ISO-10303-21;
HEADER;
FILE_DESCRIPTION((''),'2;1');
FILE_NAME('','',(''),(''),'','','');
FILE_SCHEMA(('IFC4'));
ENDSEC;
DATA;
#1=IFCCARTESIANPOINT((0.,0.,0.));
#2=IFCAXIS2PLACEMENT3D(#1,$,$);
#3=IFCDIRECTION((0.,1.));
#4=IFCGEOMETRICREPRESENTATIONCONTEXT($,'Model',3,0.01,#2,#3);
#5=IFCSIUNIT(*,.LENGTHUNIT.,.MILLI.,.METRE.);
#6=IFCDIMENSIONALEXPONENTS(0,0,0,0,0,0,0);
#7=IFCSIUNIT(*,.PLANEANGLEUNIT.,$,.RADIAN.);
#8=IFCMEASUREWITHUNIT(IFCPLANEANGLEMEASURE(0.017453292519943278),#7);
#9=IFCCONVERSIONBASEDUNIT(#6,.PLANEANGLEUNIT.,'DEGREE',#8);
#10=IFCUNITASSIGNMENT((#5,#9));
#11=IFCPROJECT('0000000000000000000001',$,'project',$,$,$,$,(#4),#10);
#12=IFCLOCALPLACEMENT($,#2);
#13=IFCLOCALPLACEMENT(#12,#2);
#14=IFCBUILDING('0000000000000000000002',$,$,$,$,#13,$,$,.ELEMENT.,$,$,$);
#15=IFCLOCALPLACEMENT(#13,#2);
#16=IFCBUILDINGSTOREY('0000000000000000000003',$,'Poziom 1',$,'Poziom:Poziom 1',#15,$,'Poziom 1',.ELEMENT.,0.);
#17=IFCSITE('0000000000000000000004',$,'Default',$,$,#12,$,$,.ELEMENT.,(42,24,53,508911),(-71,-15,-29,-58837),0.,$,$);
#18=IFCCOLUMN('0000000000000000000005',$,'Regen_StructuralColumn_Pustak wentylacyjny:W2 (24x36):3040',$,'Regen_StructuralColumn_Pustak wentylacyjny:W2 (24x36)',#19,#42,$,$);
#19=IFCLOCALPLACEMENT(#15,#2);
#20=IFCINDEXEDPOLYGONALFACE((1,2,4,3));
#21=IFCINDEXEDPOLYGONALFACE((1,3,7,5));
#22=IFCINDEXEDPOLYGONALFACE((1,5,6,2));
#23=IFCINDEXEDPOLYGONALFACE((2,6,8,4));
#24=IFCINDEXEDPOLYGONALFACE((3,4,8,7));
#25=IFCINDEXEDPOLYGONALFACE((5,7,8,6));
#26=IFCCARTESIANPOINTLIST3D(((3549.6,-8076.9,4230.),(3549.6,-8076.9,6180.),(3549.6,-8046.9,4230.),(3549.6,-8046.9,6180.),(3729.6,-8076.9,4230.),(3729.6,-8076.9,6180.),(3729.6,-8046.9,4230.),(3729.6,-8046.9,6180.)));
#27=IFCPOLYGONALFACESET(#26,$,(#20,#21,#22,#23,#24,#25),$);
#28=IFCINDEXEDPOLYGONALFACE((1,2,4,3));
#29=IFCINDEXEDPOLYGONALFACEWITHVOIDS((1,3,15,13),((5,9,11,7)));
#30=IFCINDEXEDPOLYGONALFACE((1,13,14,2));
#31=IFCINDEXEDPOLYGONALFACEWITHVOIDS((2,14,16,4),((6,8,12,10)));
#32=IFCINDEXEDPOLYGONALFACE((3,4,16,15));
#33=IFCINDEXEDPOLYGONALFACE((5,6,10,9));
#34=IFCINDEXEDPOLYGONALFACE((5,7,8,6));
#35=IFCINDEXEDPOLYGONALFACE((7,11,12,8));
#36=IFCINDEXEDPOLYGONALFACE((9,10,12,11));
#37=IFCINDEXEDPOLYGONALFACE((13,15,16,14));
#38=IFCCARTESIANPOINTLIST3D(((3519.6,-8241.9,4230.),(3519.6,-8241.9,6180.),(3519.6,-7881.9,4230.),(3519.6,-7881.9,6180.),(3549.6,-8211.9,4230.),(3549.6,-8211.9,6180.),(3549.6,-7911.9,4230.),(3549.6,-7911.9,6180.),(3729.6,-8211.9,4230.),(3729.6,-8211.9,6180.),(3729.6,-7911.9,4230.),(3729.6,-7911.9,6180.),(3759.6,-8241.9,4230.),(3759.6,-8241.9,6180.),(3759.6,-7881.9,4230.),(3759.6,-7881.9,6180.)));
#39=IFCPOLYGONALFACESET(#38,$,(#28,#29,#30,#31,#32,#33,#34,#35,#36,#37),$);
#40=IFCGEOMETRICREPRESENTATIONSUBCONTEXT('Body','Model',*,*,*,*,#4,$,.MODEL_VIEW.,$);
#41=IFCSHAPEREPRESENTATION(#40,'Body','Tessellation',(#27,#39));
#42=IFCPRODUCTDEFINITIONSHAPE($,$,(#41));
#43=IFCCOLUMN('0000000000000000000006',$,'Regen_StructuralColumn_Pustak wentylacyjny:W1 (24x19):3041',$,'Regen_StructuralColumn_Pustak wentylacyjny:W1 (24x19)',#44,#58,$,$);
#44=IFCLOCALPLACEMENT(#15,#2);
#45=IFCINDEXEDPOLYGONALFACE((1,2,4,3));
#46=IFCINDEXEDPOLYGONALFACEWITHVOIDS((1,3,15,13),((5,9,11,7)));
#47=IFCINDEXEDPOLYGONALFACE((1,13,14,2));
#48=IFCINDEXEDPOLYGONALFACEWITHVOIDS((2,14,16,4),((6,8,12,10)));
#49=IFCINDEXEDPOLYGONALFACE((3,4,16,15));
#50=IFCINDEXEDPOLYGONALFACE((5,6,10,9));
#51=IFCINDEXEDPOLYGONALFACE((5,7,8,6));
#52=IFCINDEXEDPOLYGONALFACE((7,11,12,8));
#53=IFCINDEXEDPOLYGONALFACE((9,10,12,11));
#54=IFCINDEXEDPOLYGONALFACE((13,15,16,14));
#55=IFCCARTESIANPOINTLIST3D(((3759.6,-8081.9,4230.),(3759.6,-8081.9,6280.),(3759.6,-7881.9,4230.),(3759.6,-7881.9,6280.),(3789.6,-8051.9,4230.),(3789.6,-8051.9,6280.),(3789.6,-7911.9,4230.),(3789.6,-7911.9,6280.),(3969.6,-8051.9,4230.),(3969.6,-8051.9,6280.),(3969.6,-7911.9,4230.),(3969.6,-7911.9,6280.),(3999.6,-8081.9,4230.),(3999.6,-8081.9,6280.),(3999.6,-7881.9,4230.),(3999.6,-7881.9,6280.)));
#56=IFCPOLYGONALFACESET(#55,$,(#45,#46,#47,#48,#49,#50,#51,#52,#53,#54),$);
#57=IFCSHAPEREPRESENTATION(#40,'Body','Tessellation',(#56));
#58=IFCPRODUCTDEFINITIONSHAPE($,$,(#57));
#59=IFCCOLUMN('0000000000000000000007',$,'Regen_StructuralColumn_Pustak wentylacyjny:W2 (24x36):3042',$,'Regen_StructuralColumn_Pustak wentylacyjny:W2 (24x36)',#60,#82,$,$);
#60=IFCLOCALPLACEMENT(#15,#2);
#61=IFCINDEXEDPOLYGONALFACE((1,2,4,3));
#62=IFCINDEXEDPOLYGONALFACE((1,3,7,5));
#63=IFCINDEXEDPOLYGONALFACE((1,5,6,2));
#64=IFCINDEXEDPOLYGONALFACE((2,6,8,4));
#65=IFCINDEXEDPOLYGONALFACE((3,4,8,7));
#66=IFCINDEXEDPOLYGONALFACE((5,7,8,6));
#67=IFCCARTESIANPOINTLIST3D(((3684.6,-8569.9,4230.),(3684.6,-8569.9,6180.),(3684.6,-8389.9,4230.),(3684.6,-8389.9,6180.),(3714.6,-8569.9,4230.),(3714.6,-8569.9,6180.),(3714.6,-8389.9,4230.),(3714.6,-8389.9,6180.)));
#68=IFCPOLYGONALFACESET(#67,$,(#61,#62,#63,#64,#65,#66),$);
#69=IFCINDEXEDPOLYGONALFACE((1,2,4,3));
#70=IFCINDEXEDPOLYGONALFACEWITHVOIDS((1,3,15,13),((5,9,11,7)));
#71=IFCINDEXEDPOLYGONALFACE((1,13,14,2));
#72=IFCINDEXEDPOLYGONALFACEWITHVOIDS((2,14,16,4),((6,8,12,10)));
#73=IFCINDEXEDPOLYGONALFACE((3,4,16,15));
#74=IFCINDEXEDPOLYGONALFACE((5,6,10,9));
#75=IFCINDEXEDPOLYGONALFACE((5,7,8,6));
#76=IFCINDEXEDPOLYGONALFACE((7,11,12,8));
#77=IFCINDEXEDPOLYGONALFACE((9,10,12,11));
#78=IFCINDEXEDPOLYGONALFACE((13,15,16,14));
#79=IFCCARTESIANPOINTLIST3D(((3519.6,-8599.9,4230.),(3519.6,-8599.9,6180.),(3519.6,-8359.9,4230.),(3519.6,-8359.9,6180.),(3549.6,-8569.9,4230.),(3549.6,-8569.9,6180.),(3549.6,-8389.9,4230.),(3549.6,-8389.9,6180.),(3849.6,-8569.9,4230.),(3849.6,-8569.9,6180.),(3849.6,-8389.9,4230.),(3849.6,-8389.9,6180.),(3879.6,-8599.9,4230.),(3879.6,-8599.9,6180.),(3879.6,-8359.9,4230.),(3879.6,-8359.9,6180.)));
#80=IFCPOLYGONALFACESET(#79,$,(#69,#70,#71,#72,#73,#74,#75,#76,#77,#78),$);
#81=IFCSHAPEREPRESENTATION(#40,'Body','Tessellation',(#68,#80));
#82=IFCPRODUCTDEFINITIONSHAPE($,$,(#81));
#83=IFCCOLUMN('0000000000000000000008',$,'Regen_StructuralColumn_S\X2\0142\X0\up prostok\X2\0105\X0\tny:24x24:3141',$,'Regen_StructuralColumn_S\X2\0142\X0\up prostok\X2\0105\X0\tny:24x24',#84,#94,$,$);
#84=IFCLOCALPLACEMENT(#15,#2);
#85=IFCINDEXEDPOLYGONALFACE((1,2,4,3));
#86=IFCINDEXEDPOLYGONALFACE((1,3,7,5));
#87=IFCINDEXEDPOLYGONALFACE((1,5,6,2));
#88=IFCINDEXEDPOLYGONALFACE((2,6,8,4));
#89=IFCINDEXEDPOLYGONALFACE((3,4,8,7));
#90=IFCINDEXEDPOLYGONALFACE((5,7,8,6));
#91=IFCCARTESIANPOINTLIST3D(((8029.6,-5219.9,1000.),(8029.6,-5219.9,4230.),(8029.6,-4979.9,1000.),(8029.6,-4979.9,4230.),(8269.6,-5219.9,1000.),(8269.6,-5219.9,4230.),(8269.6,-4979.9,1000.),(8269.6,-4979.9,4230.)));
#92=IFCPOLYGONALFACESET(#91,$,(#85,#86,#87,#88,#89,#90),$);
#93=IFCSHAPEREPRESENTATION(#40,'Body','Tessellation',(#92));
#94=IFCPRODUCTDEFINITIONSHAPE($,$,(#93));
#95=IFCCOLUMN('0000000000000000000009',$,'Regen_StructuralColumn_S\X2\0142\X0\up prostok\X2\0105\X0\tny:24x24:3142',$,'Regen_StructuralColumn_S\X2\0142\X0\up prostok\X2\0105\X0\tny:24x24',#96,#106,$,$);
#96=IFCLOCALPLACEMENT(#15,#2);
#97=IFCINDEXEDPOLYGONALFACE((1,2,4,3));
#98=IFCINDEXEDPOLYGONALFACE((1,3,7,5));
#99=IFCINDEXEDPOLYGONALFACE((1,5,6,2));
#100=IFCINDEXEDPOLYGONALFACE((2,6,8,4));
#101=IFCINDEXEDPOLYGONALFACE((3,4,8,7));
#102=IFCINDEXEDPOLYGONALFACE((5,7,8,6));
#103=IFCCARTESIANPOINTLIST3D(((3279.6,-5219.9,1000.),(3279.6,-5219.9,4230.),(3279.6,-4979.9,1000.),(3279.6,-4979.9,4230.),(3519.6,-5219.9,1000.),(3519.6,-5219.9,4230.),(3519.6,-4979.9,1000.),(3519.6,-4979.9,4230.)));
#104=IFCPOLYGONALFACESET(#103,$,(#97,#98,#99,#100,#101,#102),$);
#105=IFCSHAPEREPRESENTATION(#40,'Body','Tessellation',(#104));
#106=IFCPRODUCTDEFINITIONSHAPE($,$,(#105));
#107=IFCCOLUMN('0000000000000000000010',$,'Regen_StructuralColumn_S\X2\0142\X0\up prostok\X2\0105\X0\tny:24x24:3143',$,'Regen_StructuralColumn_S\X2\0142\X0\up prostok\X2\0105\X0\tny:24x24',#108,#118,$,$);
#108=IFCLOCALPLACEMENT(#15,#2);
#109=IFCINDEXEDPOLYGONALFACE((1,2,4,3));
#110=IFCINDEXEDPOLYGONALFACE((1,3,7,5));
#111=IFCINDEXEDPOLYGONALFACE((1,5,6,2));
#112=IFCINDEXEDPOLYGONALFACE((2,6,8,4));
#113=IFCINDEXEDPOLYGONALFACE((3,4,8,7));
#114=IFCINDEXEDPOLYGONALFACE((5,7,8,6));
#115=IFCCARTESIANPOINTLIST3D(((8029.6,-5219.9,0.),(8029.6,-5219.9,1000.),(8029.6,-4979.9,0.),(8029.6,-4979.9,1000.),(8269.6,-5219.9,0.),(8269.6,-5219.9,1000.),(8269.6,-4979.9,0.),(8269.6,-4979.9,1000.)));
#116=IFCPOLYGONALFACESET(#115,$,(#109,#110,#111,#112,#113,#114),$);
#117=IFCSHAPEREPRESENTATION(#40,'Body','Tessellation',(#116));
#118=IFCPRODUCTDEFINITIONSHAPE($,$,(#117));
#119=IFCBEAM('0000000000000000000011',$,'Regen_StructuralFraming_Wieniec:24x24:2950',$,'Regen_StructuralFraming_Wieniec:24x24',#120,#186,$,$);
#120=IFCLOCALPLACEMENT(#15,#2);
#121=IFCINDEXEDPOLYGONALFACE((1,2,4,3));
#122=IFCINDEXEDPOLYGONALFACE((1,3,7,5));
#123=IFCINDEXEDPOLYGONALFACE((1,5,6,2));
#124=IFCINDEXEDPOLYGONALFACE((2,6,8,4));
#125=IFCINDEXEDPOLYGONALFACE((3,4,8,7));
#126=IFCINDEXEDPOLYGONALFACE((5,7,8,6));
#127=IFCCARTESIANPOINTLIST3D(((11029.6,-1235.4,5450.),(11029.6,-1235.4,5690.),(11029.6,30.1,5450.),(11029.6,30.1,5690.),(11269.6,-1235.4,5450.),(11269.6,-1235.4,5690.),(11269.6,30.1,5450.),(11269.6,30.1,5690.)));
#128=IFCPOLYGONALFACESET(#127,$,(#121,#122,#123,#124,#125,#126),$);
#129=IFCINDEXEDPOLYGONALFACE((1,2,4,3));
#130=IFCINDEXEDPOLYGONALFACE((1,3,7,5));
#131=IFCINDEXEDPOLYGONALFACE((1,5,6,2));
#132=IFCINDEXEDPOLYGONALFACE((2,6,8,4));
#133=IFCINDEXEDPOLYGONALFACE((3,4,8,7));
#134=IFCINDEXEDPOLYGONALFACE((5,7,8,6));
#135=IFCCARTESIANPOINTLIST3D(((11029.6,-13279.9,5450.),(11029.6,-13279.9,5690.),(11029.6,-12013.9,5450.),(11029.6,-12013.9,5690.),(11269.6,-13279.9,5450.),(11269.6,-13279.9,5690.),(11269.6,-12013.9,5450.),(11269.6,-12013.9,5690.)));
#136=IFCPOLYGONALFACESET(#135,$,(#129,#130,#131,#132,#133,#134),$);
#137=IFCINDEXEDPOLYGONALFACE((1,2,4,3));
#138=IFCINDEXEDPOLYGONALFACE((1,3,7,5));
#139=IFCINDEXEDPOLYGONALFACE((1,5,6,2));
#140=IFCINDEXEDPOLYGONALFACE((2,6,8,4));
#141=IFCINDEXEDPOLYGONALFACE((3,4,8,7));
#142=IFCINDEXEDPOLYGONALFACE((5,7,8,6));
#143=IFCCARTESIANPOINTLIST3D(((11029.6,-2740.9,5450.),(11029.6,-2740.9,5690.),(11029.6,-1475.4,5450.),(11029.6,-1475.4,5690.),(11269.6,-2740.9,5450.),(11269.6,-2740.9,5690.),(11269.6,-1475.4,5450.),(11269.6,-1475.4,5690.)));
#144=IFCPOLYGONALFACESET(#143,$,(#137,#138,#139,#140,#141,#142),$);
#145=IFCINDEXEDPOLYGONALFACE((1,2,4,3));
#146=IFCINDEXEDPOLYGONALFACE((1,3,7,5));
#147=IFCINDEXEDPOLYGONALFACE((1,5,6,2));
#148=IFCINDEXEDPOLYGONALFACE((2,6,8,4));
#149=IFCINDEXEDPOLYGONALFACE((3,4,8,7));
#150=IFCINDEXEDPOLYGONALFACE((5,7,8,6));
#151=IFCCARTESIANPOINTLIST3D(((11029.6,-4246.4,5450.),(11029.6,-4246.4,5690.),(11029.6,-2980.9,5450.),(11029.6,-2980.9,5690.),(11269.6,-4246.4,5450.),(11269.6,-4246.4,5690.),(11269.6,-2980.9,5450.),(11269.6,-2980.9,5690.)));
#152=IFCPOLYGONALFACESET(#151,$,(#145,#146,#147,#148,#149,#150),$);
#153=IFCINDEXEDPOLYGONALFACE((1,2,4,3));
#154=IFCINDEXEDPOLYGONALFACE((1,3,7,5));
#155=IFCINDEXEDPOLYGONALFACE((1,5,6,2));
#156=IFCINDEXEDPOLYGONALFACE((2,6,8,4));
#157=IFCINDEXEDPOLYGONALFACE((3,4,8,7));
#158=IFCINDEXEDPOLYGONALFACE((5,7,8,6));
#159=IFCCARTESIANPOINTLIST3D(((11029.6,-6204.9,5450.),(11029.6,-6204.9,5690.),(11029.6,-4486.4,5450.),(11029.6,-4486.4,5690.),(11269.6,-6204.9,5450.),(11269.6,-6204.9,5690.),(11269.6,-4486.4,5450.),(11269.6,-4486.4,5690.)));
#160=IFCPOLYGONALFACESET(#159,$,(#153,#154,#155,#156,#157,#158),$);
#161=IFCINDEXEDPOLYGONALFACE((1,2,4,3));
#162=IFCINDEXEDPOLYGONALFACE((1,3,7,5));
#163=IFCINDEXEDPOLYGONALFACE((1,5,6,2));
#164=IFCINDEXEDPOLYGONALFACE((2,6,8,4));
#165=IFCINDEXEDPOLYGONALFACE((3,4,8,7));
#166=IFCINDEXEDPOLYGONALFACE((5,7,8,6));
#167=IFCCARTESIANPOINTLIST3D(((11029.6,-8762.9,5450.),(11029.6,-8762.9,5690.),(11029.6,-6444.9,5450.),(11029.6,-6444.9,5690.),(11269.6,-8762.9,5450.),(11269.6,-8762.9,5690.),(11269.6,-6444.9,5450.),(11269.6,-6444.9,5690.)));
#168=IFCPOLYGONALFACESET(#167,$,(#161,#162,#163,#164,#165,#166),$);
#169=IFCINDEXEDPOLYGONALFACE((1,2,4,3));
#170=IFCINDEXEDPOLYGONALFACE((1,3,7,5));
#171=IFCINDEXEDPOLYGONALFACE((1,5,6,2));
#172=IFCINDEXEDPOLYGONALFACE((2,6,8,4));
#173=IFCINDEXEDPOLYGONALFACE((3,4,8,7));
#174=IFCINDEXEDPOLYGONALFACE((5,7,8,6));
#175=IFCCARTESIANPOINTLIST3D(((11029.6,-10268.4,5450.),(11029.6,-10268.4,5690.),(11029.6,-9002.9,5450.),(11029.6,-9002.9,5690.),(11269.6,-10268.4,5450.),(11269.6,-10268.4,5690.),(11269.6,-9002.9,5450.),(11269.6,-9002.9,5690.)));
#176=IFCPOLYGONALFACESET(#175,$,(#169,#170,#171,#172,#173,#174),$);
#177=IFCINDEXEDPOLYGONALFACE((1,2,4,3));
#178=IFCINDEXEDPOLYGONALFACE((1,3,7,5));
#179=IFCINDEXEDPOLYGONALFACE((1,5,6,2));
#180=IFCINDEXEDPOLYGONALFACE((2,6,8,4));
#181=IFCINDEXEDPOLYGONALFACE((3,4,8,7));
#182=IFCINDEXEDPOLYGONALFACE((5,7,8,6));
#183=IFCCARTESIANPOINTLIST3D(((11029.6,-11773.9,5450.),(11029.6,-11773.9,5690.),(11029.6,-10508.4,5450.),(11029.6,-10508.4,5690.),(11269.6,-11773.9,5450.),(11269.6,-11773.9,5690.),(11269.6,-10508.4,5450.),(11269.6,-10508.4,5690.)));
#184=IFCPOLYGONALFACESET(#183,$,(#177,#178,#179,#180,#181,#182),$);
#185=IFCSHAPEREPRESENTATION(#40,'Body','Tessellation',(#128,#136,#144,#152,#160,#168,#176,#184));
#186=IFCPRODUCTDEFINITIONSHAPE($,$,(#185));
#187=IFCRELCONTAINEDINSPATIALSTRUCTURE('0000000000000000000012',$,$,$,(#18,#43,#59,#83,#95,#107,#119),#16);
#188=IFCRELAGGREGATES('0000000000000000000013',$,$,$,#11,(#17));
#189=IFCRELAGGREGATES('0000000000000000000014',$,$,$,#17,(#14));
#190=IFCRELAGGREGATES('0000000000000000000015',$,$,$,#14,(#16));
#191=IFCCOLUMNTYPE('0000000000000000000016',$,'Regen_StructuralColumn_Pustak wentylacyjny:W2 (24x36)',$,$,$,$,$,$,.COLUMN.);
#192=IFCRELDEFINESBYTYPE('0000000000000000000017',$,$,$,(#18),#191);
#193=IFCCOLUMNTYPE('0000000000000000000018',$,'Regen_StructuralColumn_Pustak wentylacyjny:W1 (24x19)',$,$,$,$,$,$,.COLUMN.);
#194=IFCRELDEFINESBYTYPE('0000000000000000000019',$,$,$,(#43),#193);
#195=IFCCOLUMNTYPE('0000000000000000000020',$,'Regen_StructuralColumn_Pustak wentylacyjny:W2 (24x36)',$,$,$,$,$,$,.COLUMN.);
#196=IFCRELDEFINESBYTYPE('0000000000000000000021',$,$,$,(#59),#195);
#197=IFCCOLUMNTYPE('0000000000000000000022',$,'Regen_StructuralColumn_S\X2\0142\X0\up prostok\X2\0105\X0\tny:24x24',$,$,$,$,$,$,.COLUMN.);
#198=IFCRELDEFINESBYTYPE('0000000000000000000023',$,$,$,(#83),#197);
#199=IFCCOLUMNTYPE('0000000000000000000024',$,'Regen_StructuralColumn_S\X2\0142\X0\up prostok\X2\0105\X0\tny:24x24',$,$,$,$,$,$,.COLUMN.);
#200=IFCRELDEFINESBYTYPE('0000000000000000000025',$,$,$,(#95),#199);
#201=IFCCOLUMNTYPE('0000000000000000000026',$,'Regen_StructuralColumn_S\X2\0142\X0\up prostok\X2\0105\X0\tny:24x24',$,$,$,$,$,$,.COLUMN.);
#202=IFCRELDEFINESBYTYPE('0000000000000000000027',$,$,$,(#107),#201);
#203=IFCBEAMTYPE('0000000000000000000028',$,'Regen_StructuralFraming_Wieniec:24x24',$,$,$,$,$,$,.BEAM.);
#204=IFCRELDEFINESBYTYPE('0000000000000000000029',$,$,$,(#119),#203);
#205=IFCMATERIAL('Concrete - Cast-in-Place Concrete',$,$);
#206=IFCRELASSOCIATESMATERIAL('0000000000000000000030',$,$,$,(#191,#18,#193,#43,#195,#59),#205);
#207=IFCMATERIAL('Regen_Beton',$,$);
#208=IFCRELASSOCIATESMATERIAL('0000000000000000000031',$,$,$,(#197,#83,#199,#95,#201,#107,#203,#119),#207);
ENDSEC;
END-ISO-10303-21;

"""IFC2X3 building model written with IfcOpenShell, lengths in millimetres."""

from ifc_helpers import new_model, entity, si_unit, converted_unit, direction, frame, frame_2d, origin, place, context, subcontext, project, spatial, polyline, rectangle, outline, extrude, source, transform, mapped, material, type_object, type_shapes, element, save


model = new_model("IFC2X3")

# Units and contexts
model_context = context("Model", 3, precision=0.01, world=origin(), true_north=direction((0.0, 1.0)))
body_context = subcontext(model_context, "Body", "Model", "MODEL_VIEW")
ifc_project = project(units=[si_unit("LENGTHUNIT", "METRE", prefix="MILLI"), converted_unit("PLANEANGLEUNIT", "DEGREE", entity("IfcPlaneAngleMeasure", 0.017453292519943278), si_unit("PLANEANGLEUNIT", "RADIAN"), dimensions=[0, 0, 0, 0, 0, 0, 0])], contexts=[model_context])

# Site, building, storey
site_placement = place(None, origin())
site = spatial("IfcSite", under=ifc_project, at=site_placement, Name="Default", CompositionType="ELEMENT", RefLatitude=(42, 24, 53, 508911), RefLongitude=(-71, -15, -29, -58837), RefElevation=0.0)
building_placement = place(site_placement, origin())
building = spatial("IfcBuilding", under=site, at=building_placement, CompositionType="ELEMENT")
storey_placement = place(building_placement, origin())
storey = spatial("IfcBuildingStorey", under=building, at=storey_placement, Name="Poziom 1", ObjectType="Poziom:Poziom 1", LongName="Poziom 1", CompositionType="ELEMENT", Elevation=0.0)

# Columns
ifc_material_1 = material(Name="Regen_Beton")
ifc_material_2 = material(Name="Concrete - Cast-in-Place Concrete")
column_type_1 = type_object("IfcColumnType", Name="Regen_StructuralColumn_Pustak wentylacyjny:W2 (24x36)", PredefinedType="COLUMN", material=ifc_material_2)
shared_shape_1 = source(origin(), body_context, "Body", "SweptSolid", [
    extrude(rectangle(XDim=180.0, YDim=30.0, at=frame_2d((0.0, 0.0), x_axis=(1.0, 0.0))), frame((3639.6, -8061.9, 4230.0)), (0.0, 0.0, 1.0), 1950.0),
    extrude(outline(polyline([(-120.0, -180.0), (120.0, -180.0), (120.0, 180.0), (-120.0, 180.0), (-120.0, -180.0)]), holes=[polyline([(-90.0, 150.0), (90.0, 150.0), (90.0, -150.0), (-90.0, -150.0), (-90.0, 150.0)])]), frame((3639.6, -8061.9, 4230.0)), (0.0, 0.0, 1.0), 1950.0),
])
type_shapes(column_type_1, [shared_shape_1])
column_1_placement = place(storey_placement, origin())
element("IfcColumn", 1, at=column_1_placement, inside=storey, type_object=column_type_1, material=ifc_material_2, Name="Regen_StructuralColumn_Pustak wentylacyjny:W2 (24x36):3040", ObjectType="Regen_StructuralColumn_Pustak wentylacyjny:W2 (24x36)", context=body_context, shape_type="MappedRepresentation", body=[
    mapped(shared_shape_1, transform((0.0, 0.0, 0.0), scale=1.0)),
])
column_type_2 = type_object("IfcColumnType", Name="Regen_StructuralColumn_Pustak wentylacyjny:W1 (24x19)", PredefinedType="COLUMN", material=ifc_material_2)
shared_shape_2 = source(origin(), body_context, "Body", "SweptSolid", [
    extrude(outline(polyline([(-120.0, -100.0), (120.0, -100.0), (120.0, 100.0), (-120.0, 100.0), (-120.0, -100.0)]), holes=[polyline([(-90.0, 70.0), (90.0, 70.0), (90.0, -70.0), (-90.0, -70.0), (-90.0, 70.0)])]), frame((3879.6, -7981.9, 4230.0)), (0.0, 0.0, 1.0), 2050.0),
])
type_shapes(column_type_2, [shared_shape_2])
column_2_placement = place(storey_placement, origin())
element("IfcColumn", 2, at=column_2_placement, inside=storey, type_object=column_type_2, material=ifc_material_2, Name="Regen_StructuralColumn_Pustak wentylacyjny:W1 (24x19):3041", ObjectType="Regen_StructuralColumn_Pustak wentylacyjny:W1 (24x19)", context=body_context, shape_type="MappedRepresentation", body=[
    mapped(shared_shape_2, transform((0.0, 0.0, 0.0), scale=1.0)),
])
column_type_3 = type_object("IfcColumnType", Name="Regen_StructuralColumn_Pustak wentylacyjny:W2 (24x36)", PredefinedType="COLUMN", material=ifc_material_2)
shared_shape_3 = source(origin(), body_context, "Body", "SweptSolid", [
    extrude(rectangle(XDim=180.0, YDim=30.0, at=frame_2d((0.0, 0.0), x_axis=(1.0, 0.0))), frame((3699.6, -8479.9, 4230.0), z_axis=(0.0, 0.0, 1.0), x_axis=(0.0, 1.0, 0.0)), (0.0, 0.0, 1.0), 1950.0),
    extrude(outline(polyline([(-120.0, -180.0), (120.0, -180.0), (120.0, 180.0), (-120.0, 180.0), (-120.0, -180.0)]), holes=[polyline([(-90.0, 150.0), (90.0, 150.0), (90.0, -150.0), (-90.0, -150.0), (-90.0, 150.0)])]), frame((3699.6, -8479.9, 4230.0), z_axis=(0.0, 0.0, 1.0), x_axis=(0.0, 1.0, 0.0)), (0.0, 0.0, 1.0), 1950.0),
])
type_shapes(column_type_3, [shared_shape_3])
column_3_placement = place(storey_placement, origin())
element("IfcColumn", 3, at=column_3_placement, inside=storey, type_object=column_type_3, material=ifc_material_2, Name="Regen_StructuralColumn_Pustak wentylacyjny:W2 (24x36):3042", ObjectType="Regen_StructuralColumn_Pustak wentylacyjny:W2 (24x36)", context=body_context, shape_type="MappedRepresentation", body=[
    mapped(shared_shape_3, transform((0.0, 0.0, 0.0), scale=1.0)),
])
column_type_4 = type_object("IfcColumnType", Name="Regen_StructuralColumn_Słup prostokątny:24x24", PredefinedType="COLUMN", material=ifc_material_1)
shared_shape_4 = source(origin(), body_context, "Body", "SweptSolid", [
    extrude(rectangle(XDim=240.0, YDim=240.0, at=frame_2d((0.0, 0.0), x_axis=(1.0, 0.0))), frame((8149.6, -5099.9, 1000.0), z_axis=(0.0, 0.0, 1.0), x_axis=(-1.0, 0.0, 0.0)), (0.0, 0.0, 1.0), 3230.0),
])
type_shapes(column_type_4, [shared_shape_4])
column_4_placement = place(storey_placement, origin())
element("IfcColumn", 4, at=column_4_placement, inside=storey, type_object=column_type_4, material=ifc_material_1, Name="Regen_StructuralColumn_Słup prostokątny:24x24:3141", ObjectType="Regen_StructuralColumn_Słup prostokątny:24x24", context=body_context, shape_type="MappedRepresentation", body=[
    mapped(shared_shape_4, transform((0.0, 0.0, 0.0), scale=1.0)),
])
column_type_5 = type_object("IfcColumnType", Name="Regen_StructuralColumn_Słup prostokątny:24x24", PredefinedType="COLUMN", material=ifc_material_1)
shared_shape_5 = source(origin(), body_context, "Body", "SweptSolid", [
    extrude(rectangle(XDim=240.0, YDim=240.0, at=frame_2d((0.0, 0.0), x_axis=(1.0, 0.0))), frame((3399.6, -5099.9, 1000.0), z_axis=(0.0, 0.0, 1.0), x_axis=(-1.0, 0.0, 0.0)), (0.0, 0.0, 1.0), 3230.0),
])
type_shapes(column_type_5, [shared_shape_5])
column_5_placement = place(storey_placement, origin())
element("IfcColumn", 5, at=column_5_placement, inside=storey, type_object=column_type_5, material=ifc_material_1, Name="Regen_StructuralColumn_Słup prostokątny:24x24:3142", ObjectType="Regen_StructuralColumn_Słup prostokątny:24x24", context=body_context, shape_type="MappedRepresentation", body=[
    mapped(shared_shape_5, transform((0.0, 0.0, 0.0), scale=1.0)),
])
column_type_6 = type_object("IfcColumnType", Name="Regen_StructuralColumn_Słup prostokątny:24x24", PredefinedType="COLUMN", material=ifc_material_1)
shared_shape_6 = source(origin(), body_context, "Body", "SweptSolid", [
    extrude(rectangle(XDim=240.0, YDim=240.0, at=frame_2d((0.0, 0.0), x_axis=(1.0, 0.0))), frame((8149.6, -5099.9, 0.0), z_axis=(0.0, 0.0, 1.0), x_axis=(-1.0, 0.0, 0.0)), (0.0, 0.0, 1.0), 1000.0),
])
type_shapes(column_type_6, [shared_shape_6])
column_6_placement = place(storey_placement, origin())
element("IfcColumn", 6, at=column_6_placement, inside=storey, type_object=column_type_6, material=ifc_material_1, Name="Regen_StructuralColumn_Słup prostokątny:24x24:3143", ObjectType="Regen_StructuralColumn_Słup prostokątny:24x24", context=body_context, shape_type="MappedRepresentation", body=[
    mapped(shared_shape_6, transform((0.0, 0.0, 0.0), scale=1.0)),
])

# Beam
beam_type_1 = type_object("IfcBeamType", Name="Regen_StructuralFraming_Wieniec:24x24", PredefinedType="BEAM", material=ifc_material_1)
shared_shape_7 = source(origin(), body_context, "Body", "SweptSolid", [
    extrude(rectangle(XDim=240.0, YDim=240.0, at=frame_2d((0.0, 0.0), x_axis=(0.0, 1.0))), frame((11149.6, -1235.4, 5570.0), z_axis=(0.0, 1.0, 0.0), x_axis=(-1.0, 0.0, 0.0)), (0.0, 0.0, 1.0), 1265.5),
    extrude(rectangle(XDim=240.0, YDim=240.0, at=frame_2d((0.0, 0.0), x_axis=(0.0, 1.0))), frame((11149.6, -13279.9, 5570.0), z_axis=(0.0, 1.0, 0.0), x_axis=(-1.0, 0.0, 0.0)), (0.0, 0.0, 1.0), 1266.0),
    extrude(rectangle(XDim=240.0, YDim=240.0, at=frame_2d((0.0, 0.0), x_axis=(0.0, 1.0))), frame((11149.6, -2740.9, 5570.0), z_axis=(0.0, 1.0, 0.0), x_axis=(-1.0, 0.0, 0.0)), (0.0, 0.0, 1.0), 1265.5),
    extrude(rectangle(XDim=240.0, YDim=240.0, at=frame_2d((0.0, 0.0), x_axis=(0.0, 1.0))), frame((11149.6, -4246.4, 5570.0), z_axis=(0.0, 1.0, 0.0), x_axis=(-1.0, 0.0, 0.0)), (0.0, 0.0, 1.0), 1265.5),
    extrude(rectangle(XDim=240.0, YDim=240.0, at=frame_2d((0.0, 0.0), x_axis=(0.0, 1.0))), frame((11149.6, -6204.9, 5570.0), z_axis=(0.0, 1.0, 0.0), x_axis=(-1.0, 0.0, 0.0)), (0.0, 0.0, 1.0), 1718.5),
    extrude(rectangle(XDim=240.0, YDim=240.0, at=frame_2d((0.0, 0.0), x_axis=(0.0, 1.0))), frame((11149.6, -8762.9, 5570.0), z_axis=(0.0, 1.0, 0.0), x_axis=(-1.0, 0.0, 0.0)), (0.0, 0.0, 1.0), 2318.0),
    extrude(rectangle(XDim=240.0, YDim=240.0, at=frame_2d((0.0, 0.0), x_axis=(0.0, 1.0))), frame((11149.6, -10268.4, 5570.0), z_axis=(0.0, 1.0, 0.0), x_axis=(-1.0, 0.0, 0.0)), (0.0, 0.0, 1.0), 1265.5),
    extrude(rectangle(XDim=240.0, YDim=240.0, at=frame_2d((0.0, 0.0), x_axis=(0.0, 1.0))), frame((11149.6, -11773.9, 5570.0), z_axis=(0.0, 1.0, 0.0), x_axis=(-1.0, 0.0, 0.0)), (0.0, 0.0, 1.0), 1265.5),
])
type_shapes(beam_type_1, [shared_shape_7])
beam_1_placement = place(storey_placement, origin())
element("IfcBeam", 7, at=beam_1_placement, inside=storey, type_object=beam_type_1, material=ifc_material_1, Name="Regen_StructuralFraming_Wieniec:24x24:2950", ObjectType="Regen_StructuralFraming_Wieniec:24x24", context=body_context, shape_type="MappedRepresentation", body=[
    mapped(shared_shape_7, transform((0.0, 0.0, 0.0), scale=1.0)),
])

save(model, "model.ifc")
